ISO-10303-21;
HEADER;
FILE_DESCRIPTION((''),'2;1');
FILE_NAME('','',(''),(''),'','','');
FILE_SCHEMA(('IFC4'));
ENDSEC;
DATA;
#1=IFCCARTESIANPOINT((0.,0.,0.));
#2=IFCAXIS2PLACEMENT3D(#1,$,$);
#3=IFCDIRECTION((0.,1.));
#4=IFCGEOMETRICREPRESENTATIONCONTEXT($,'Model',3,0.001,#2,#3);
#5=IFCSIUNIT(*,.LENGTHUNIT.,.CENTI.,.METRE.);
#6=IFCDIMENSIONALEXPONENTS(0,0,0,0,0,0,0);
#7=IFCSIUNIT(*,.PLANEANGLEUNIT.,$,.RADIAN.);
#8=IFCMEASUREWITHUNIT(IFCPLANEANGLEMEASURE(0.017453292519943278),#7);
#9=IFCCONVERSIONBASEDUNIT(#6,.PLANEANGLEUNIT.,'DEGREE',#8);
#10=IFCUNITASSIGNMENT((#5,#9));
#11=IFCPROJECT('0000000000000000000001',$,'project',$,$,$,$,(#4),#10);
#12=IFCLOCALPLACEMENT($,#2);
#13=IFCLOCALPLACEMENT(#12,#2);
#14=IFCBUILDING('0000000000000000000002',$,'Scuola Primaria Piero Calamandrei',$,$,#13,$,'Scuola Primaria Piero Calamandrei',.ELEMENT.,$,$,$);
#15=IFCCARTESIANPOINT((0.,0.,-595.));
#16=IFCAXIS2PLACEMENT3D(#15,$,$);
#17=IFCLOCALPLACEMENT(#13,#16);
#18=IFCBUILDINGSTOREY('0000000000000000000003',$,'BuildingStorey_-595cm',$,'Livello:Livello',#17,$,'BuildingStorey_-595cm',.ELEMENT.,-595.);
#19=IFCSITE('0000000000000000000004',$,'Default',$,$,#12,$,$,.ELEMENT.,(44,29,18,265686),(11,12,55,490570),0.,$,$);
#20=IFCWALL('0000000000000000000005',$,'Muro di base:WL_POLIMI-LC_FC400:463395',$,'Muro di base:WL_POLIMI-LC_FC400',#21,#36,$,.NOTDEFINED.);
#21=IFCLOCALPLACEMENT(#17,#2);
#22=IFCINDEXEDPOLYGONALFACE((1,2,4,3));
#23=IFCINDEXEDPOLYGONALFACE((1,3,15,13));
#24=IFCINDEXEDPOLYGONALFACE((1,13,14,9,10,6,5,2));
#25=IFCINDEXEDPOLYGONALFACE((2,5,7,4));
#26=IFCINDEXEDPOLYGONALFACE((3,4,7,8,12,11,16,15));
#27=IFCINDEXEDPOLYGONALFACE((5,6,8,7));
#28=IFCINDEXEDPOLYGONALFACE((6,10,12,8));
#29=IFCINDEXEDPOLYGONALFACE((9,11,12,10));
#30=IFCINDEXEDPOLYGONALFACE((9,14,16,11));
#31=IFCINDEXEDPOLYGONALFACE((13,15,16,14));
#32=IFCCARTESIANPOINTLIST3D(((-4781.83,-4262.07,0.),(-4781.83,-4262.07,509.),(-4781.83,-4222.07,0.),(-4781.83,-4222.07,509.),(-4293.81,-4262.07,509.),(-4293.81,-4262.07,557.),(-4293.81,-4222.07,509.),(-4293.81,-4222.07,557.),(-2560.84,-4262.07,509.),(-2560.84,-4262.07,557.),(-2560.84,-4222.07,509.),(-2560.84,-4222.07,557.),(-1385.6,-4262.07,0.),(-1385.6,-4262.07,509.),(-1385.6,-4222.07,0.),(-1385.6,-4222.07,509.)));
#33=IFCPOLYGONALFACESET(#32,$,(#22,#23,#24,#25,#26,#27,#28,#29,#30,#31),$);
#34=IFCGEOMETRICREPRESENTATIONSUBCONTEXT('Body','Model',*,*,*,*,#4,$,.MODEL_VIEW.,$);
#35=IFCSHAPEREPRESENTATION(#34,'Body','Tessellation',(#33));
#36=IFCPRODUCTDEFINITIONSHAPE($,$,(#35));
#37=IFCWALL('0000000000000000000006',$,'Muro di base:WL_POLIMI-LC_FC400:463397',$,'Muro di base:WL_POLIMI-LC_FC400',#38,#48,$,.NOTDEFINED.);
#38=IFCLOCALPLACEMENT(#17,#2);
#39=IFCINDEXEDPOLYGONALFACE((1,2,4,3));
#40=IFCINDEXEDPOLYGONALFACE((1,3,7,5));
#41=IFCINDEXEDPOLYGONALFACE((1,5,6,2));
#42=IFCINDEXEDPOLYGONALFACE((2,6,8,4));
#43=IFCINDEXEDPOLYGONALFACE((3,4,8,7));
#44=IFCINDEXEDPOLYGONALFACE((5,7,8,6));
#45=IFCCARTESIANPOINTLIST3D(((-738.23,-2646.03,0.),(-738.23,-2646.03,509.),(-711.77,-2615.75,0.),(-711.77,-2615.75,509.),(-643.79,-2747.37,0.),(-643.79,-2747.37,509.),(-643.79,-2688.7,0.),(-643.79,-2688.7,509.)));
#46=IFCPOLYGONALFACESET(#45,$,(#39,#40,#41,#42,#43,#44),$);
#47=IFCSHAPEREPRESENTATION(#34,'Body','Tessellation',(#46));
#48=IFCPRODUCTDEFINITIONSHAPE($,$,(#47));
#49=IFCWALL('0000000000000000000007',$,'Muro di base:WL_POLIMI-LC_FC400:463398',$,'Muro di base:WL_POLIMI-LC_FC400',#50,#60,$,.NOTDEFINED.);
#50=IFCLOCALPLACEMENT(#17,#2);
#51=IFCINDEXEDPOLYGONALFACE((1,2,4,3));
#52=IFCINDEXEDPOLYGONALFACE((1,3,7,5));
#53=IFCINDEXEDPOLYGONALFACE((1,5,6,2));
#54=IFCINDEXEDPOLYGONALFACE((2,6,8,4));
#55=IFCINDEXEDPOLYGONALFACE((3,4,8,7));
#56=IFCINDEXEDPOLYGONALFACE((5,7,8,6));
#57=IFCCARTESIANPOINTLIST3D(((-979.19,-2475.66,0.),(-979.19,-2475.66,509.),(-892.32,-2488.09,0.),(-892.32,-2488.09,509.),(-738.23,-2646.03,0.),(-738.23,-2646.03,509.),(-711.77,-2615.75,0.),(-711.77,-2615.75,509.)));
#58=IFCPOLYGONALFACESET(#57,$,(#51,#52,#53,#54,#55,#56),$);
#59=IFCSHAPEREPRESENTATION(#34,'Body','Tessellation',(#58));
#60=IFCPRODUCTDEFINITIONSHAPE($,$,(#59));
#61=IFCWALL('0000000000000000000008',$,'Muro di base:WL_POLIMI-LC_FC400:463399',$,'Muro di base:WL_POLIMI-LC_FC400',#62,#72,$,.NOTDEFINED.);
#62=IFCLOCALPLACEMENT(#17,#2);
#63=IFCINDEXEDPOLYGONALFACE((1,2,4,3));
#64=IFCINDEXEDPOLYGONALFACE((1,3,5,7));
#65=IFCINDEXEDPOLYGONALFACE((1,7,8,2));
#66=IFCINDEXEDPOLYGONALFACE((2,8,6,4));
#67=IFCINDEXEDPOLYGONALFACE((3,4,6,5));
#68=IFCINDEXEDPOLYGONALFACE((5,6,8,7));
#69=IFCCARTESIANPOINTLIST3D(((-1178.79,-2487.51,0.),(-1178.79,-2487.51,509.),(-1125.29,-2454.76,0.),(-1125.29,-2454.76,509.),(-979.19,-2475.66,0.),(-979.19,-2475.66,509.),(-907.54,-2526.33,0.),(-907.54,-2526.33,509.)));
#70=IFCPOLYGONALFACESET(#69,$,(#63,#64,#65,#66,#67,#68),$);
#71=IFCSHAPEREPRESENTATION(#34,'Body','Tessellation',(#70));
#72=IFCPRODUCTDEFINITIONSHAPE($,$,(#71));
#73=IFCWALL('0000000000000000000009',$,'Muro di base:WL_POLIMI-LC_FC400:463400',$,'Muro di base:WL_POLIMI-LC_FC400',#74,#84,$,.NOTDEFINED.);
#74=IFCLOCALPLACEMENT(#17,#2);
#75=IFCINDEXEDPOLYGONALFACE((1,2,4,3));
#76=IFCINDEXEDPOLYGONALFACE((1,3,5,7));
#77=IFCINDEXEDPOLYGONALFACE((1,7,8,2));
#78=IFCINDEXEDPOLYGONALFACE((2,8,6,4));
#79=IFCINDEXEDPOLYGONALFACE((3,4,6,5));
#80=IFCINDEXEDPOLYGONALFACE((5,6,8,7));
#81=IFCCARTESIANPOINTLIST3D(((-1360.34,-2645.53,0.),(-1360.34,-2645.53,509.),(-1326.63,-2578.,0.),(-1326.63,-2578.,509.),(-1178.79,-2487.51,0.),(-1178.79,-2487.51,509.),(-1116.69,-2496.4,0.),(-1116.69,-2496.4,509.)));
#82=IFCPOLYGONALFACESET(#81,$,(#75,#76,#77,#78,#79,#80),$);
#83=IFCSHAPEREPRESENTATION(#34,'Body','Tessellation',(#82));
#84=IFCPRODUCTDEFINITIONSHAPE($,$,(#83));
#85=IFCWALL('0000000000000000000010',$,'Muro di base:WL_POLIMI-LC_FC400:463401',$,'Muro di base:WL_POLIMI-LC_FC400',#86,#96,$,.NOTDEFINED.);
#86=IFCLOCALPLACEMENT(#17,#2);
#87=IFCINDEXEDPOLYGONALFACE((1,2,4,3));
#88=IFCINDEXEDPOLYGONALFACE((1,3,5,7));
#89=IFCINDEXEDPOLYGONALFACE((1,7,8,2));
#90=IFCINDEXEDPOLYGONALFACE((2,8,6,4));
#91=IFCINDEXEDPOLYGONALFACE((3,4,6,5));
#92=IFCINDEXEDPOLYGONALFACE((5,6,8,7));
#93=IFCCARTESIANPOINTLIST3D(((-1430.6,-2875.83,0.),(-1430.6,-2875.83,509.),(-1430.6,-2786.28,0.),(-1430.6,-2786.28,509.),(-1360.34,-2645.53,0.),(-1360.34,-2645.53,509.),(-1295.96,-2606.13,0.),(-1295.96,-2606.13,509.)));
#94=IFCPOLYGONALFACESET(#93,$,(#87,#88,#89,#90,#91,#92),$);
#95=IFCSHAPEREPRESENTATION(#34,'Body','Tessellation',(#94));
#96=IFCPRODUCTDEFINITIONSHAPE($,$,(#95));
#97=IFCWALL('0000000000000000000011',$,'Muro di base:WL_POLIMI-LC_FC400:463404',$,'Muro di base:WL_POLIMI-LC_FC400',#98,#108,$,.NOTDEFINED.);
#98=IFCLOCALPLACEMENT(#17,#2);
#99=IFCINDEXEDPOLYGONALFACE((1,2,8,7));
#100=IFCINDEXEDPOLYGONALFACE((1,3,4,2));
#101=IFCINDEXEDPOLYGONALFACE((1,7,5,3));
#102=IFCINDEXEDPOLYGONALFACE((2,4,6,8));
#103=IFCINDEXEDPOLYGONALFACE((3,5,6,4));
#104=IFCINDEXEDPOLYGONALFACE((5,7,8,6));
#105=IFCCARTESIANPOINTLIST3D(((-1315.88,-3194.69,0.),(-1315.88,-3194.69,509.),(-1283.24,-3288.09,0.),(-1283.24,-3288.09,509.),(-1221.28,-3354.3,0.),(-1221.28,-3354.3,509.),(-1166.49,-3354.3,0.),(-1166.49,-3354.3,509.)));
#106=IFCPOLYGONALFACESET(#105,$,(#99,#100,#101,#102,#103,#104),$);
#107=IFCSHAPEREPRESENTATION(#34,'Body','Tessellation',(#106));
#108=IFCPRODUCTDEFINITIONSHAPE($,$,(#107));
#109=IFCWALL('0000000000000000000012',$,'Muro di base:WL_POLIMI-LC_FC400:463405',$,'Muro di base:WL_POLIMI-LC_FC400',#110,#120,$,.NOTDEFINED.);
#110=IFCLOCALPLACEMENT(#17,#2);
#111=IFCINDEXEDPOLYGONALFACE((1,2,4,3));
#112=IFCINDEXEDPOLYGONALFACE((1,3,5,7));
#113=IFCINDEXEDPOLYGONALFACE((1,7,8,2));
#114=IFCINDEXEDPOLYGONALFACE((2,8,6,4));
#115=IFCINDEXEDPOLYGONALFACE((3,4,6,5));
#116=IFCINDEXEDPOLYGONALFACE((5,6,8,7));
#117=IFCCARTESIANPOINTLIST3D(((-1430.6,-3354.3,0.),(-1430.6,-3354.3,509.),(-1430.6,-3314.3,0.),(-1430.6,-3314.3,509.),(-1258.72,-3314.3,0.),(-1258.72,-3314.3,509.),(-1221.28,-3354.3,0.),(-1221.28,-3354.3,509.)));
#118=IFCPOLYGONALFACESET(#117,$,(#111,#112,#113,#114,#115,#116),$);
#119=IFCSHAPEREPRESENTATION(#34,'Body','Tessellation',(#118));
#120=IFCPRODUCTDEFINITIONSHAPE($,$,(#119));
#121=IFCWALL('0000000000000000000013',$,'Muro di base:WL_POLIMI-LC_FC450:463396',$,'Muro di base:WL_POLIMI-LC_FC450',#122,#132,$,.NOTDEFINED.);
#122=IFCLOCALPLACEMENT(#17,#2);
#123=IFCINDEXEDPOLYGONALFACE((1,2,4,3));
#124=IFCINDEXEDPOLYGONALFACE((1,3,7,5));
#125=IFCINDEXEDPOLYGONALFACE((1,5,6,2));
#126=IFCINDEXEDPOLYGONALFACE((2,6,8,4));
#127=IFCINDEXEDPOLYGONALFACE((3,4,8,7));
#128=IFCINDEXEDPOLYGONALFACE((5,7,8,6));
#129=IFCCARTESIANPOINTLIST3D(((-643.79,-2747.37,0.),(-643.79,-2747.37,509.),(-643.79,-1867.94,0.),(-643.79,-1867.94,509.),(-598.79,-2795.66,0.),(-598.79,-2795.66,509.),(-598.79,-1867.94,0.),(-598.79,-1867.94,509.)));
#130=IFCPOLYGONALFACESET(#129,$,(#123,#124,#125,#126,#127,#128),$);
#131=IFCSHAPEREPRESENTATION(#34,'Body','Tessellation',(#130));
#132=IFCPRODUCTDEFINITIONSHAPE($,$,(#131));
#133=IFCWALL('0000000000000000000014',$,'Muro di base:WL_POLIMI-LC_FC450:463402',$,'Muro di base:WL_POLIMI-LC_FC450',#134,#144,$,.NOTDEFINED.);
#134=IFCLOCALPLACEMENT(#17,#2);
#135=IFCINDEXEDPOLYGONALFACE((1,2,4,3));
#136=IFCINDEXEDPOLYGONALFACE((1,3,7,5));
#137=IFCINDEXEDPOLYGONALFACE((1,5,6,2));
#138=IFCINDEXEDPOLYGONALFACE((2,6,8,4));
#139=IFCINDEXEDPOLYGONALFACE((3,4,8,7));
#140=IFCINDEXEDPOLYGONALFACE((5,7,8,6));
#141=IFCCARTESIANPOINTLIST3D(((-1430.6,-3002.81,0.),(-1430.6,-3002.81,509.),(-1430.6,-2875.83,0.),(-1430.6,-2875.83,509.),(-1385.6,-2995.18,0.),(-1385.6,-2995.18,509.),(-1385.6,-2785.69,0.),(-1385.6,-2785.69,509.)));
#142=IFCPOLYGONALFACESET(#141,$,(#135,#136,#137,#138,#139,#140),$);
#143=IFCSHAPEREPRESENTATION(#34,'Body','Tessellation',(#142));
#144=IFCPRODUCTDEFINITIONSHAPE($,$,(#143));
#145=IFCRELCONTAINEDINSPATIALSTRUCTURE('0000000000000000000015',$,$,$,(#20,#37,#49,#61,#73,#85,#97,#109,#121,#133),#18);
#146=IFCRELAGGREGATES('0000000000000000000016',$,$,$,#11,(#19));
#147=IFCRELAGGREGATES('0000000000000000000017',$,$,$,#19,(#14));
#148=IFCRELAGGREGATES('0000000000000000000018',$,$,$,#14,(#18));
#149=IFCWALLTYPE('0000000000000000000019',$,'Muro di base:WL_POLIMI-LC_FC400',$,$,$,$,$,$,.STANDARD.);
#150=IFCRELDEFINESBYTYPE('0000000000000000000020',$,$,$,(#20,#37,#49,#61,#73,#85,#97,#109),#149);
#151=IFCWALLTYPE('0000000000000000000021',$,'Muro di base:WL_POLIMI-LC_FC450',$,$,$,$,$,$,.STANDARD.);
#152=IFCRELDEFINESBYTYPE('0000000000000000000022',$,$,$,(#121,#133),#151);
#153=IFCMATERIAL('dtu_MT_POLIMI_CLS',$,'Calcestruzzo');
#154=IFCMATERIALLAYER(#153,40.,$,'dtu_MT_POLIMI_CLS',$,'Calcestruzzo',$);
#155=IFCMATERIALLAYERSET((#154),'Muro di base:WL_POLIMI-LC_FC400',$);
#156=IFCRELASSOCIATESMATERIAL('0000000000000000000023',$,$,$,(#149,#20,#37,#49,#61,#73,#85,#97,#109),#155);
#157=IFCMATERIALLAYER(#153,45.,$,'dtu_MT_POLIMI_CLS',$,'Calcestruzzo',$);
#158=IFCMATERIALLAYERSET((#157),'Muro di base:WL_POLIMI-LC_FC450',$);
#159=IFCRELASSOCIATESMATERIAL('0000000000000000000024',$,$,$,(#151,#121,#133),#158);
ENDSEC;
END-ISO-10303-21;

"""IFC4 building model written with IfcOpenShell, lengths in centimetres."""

from ifc_helpers import new_model, entity, si_unit, converted_unit, direction, frame, frame_2d, origin, place, context, subcontext, project, spatial, polyline, rectangle, outline, extrude, clip, bounded_halfspace, material, layer, layer_set, layer_usage, type_object, element, save


model = new_model("IFC4")

# Units and contexts
model_context = context("Model", 3, precision=0.001, world=origin(), true_north=direction((0.0, 1.0)))
body_context = subcontext(model_context, "Body", "Model", "MODEL_VIEW")
ifc_project = project(units=[si_unit("LENGTHUNIT", "METRE", prefix="CENTI"), converted_unit("PLANEANGLEUNIT", "DEGREE", entity("IfcPlaneAngleMeasure", 0.017453292519943278), si_unit("PLANEANGLEUNIT", "RADIAN"), dimensions=[0, 0, 0, 0, 0, 0, 0])], contexts=[model_context])

# Site, building, storey
site_placement = place(None, origin())
site = spatial("IfcSite", under=ifc_project, at=site_placement, Name="Default", CompositionType="ELEMENT", RefLatitude=(44, 29, 18, 265686), RefLongitude=(11, 12, 55, 490570), RefElevation=0.0)
building_placement = place(site_placement, origin())
building = spatial("IfcBuilding", under=site, at=building_placement, Name="Scuola Primaria Piero Calamandrei", LongName="Scuola Primaria Piero Calamandrei", CompositionType="ELEMENT")
storey_placement = place(building_placement, frame((0.0, 0.0, -595.0)))
storey = spatial("IfcBuildingStorey", under=building, at=storey_placement, Name="BuildingStorey_-595cm", ObjectType="Livello:Livello", LongName="BuildingStorey_-595cm", CompositionType="ELEMENT", Elevation=-595.0)

# Walls
ifc_material_1 = material(Name="dtu_MT_POLIMI_CLS", Category="Calcestruzzo")
ifc_layer_1 = layer(ifc_material_1, 40.0, Name="dtu_MT_POLIMI_CLS", Category="Calcestruzzo")
ifc_layer_set_1 = layer_set([ifc_layer_1], Name="Muro di base:WL_POLIMI-LC_FC400")
ifc_layer_usage_1 = layer_usage(ifc_layer_set_1, "AXIS2", "NEGATIVE", 20.0)
wall_type_1 = type_object("IfcWallType", Name="Muro di base:WL_POLIMI-LC_FC400", PredefinedType="STANDARD", material=ifc_layer_set_1)
wall_1_placement = place(storey_placement, frame((-1385.6, -4242.07, 0.0), z_axis=(0.0, 0.0, 1.0), x_axis=(-1.0, 0.0, 0.0)))
element("IfcWall", 1, at=wall_1_placement, inside=storey, type_object=wall_type_1, material=ifc_layer_usage_1, Name="Muro di base:WL_POLIMI-LC_FC400:463395", ObjectType="Muro di base:WL_POLIMI-LC_FC400", PredefinedType="NOTDEFINED", context=body_context, shape_type="Clipping", body=[
    clip(clip(clip(extrude(rectangle(XDim=3396.23, YDim=40.0, at=frame_2d((1698.11, 0.0), x_axis=(-1.0, 0.0))), origin(), (0.0, 0.0, 1.0), 557.0), bounded_halfspace(frame((1175.23, -20.0, 557.0), z_axis=(0.0, 0.0, -1.0), x_axis=(-1.0, 0.0, 0.0)), True, frame((1175.23, -20.0, 557.0)), polyline([(0.0, 0.0), (1732.97, 0.0), (1732.97, 40.0), (0.0, 40.0), (0.0, 0.0)]))), bounded_halfspace(frame((0.0, -20.0, 509.0), z_axis=(0.0, 0.0, 1.0), x_axis=(-1.0, 0.0, 0.0)), False, frame((0.0, -20.0, 509.0)), polyline([(0.0, 0.0), (45.0, 0.0), (1175.23, 0.0), (1175.23, 40.0), (0.0, 40.0), (0.0, 0.0)]))), bounded_halfspace(frame((2908.21, -20.0, 509.0), z_axis=(0.0, 0.0, 1.0), x_axis=(-1.0, 0.0, 0.0)), False, frame((2908.21, -20.0, 509.0)), polyline([(0.0, 0.0), (473.52, 0.0), (488.02, 0.0), (488.02, 40.0), (0.0, 40.0), (0.0, 0.0)]))),
])
ifc_layer_usage_2 = layer_usage(ifc_layer_set_1, "AXIS2", "NEGATIVE", 20.0)
wall_2_placement = place(storey_placement, frame((-629.16, -2733.74, 0.0), z_axis=(0.0, 0.0, 1.0), x_axis=(-0.681735, 0.731599, 0.0)))
element("IfcWall", 2, at=wall_2_placement, inside=storey, type_object=wall_type_1, material=ifc_layer_usage_2, Name="Muro di base:WL_POLIMI-LC_FC400:463397", ObjectType="Muro di base:WL_POLIMI-LC_FC400", PredefinedType="NOTDEFINED", context=body_context, shape_type="Clipping", body=[
    clip(extrude(outline(polyline([(142.64, -20.0), (138.52, 20.0), (0.0, 20.0), (42.93, -20.0), (142.64, -20.0)])), origin(), (0.0, 0.0, 1.0), 509.0), bounded_halfspace(frame((42.93, -20.0, 509.0), z_axis=(0.0, 0.0, 1.0), x_axis=(-0.681735, -0.731599, 0.0)), False, frame((42.93, -20.0, 509.0)), polyline([(0.0, 0.0), (99.71, 0.0), (95.6, 40.0), (-42.93, 40.0), (0.0, 0.0)]))),
])
ifc_layer_usage_3 = layer_usage(ifc_layer_set_1, "AXIS2", "NEGATIVE", 20.0)
wall_3_placement = place(storey_placement, frame((-723.32, -2632.08, 0.0), z_axis=(0.0, 0.0, 1.0), x_axis=(-0.816533, 0.577299, 0.0)))
element("IfcWall", 3, at=wall_3_placement, inside=storey, type_object=wall_type_1, material=ifc_layer_usage_3, Name="Muro di base:WL_POLIMI-LC_FC400:463398", ObjectType="Muro di base:WL_POLIMI-LC_FC400", PredefinedType="NOTDEFINED", context=body_context, shape_type="Clipping", body=[
    clip(extrude(outline(polyline([(221.12, -20.0), (299.23, 20.0), (211.48, 20.0), (4.12, 20.0), (0.0, -20.0), (221.12, -20.0)])), origin(), (0.0, 0.0, 1.0), 509.0), bounded_halfspace(frame((0.0, -20.0, 509.0), z_axis=(0.0, 0.0, 1.0), x_axis=(-0.816533, -0.577299, 0.0)), False, frame((0.0, -20.0, 509.0)), polyline([(0.0, 0.0), (221.12, 0.0), (299.23, 40.0), (211.48, 40.0), (4.12, 40.0), (0.0, 0.0)]))),
])
ifc_layer_usage_4 = layer_usage(ifc_layer_set_1, "AXIS2", "NEGATIVE", 20.0)
wall_4_placement = place(storey_placement, frame((-904.71, -2506.53, 0.0), z_axis=(0.0, 0.0, 1.0), x_axis=(-0.989918, 0.141644, 0.0)))
element("IfcWall", 4, at=wall_4_placement, inside=storey, type_object=wall_type_1, material=ifc_layer_usage_4, Name="Muro di base:WL_POLIMI-LC_FC400:463399", ObjectType="Muro di base:WL_POLIMI-LC_FC400", PredefinedType="NOTDEFINED", context=body_context, shape_type="Clipping", body=[
    clip(extrude(outline(polyline([(225.69, -20.0), (274.02, 20.0), (211.28, 20.0), (0.0, 20.0), (78.11, -20.0), (225.69, -20.0)])), origin(), (0.0, 0.0, 1.0), 509.0), bounded_halfspace(frame((78.11, -20.0, 509.0), z_axis=(0.0, 0.0, 1.0), x_axis=(-0.989918, -0.141644, 0.0)), False, frame((78.11, -20.0, 509.0)), polyline([(0.0, 0.0), (147.58, 0.0), (195.91, 40.0), (133.18, 40.0), (-78.11, 40.0), (0.0, 0.0)]))),
])
ifc_layer_usage_5 = layer_usage(ifc_layer_set_1, "AXIS2", "NEGATIVE", 20.0)
wall_5_placement = place(storey_placement, frame((-1127.13, -2479.34, 0.0), z_axis=(0.0, 0.0, 1.0), x_axis=(-0.85291, -0.522058, 0.0)))
element("IfcWall", 5, at=wall_5_placement, inside=storey, type_object=wall_type_1, material=ifc_layer_usage_5, Name="Muro di base:WL_POLIMI-LC_FC400:463400", ObjectType="Muro di base:WL_POLIMI-LC_FC400", PredefinedType="NOTDEFINED", context=body_context, shape_type="Clipping", body=[
    clip(extrude(outline(polyline([(221.66, -20.0), (285.67, 20.0), (210.19, 20.0), (0.0, 20.0), (48.33, -20.0), (221.66, -20.0)])), origin(), (0.0, 0.0, 1.0), 509.0), bounded_halfspace(frame((48.33, -20.0, 509.0), z_axis=(0.0, 0.0, 1.0), x_axis=(-0.85291, 0.522058, 0.0)), False, frame((48.33, -20.0, 509.0)), polyline([(0.0, 0.0), (173.33, 0.0), (237.34, 40.0), (161.86, 40.0), (-48.33, 40.0), (0.0, 0.0)]))),
])
ifc_layer_usage_6 = layer_usage(ifc_layer_set_1, "AXIS2", "NEGATIVE", 20.0)
wall_6_placement = place(storey_placement, frame((-1313.86, -2597.2, 0.0), z_axis=(0.0, 0.0, 1.0), x_axis=(-0.446642, -0.894713, 0.0)))
element("IfcWall", 6, at=wall_6_placement, inside=storey, type_object=wall_type_1, material=ifc_layer_usage_6, Name="Muro di base:WL_POLIMI-LC_FC400:463401", ObjectType="Muro di base:WL_POLIMI-LC_FC400", PredefinedType="NOTDEFINED", context=body_context, shape_type="Clipping", body=[
    clip(extrude(outline(polyline([(221.31, -20.0), (301.44, 20.0), (200.69, 20.0), (0.0, 20.0), (64.01, -20.0), (221.31, -20.0)])), origin(), (0.0, 0.0, 1.0), 509.0), bounded_halfspace(frame((64.01, -20.0, 509.0), z_axis=(0.0, 0.0, 1.0), x_axis=(-0.446642, 0.894713, 0.0)), False, frame((64.01, -20.0, 509.0)), polyline([(0.0, 0.0), (157.3, 0.0), (237.43, 40.0), (136.68, 40.0), (-64.01, 40.0), (0.0, 0.0)]))),
])
ifc_layer_usage_7 = layer_usage(ifc_layer_set_1, "AXIS2", "NEGATIVE", 20.0)
wall_7_placement = place(storey_placement, frame((-1330.49, -3208.35, 0.0), z_axis=(0.0, 0.0, 1.0), x_axis=(0.683359, -0.730082, 0.0)))
element("IfcWall", 7, at=wall_7_placement, inside=storey, type_object=wall_type_1, material=ifc_layer_usage_7, Name="Muro di base:WL_POLIMI-LC_FC400:463404", ObjectType="Muro di base:WL_POLIMI-LC_FC400", PredefinedType="NOTDEFINED", context=body_context, shape_type="Clipping", body=[
    clip(extrude(outline(polyline([(181.18, -20.0), (218.62, 20.0), (0.0, 20.0), (90.5, -20.0), (126.39, -20.0), (181.18, -20.0)])), origin(), (0.0, 0.0, 1.0), 509.0), bounded_halfspace(frame((90.5, -20.0, 509.0), z_axis=(0.0, 0.0, 1.0), x_axis=(0.683359, 0.730082, 0.0)), False, frame((90.5, -20.0, 509.0)), polyline([(0.0, 0.0), (35.89, 0.0), (90.68, 0.0), (128.12, 40.0), (-90.5, 40.0), (0.0, 0.0)]))),
])
ifc_layer_usage_8 = layer_usage(ifc_layer_set_1, "AXIS2", "NEGATIVE", 20.0)
wall_8_placement = place(storey_placement, frame((-1221.28, -3334.3, 0.0), z_axis=(0.0, 0.0, 1.0), x_axis=(-1.0, 0.0, 0.0)))
element("IfcWall", 8, at=wall_8_placement, inside=storey, type_object=wall_type_1, material=ifc_layer_usage_8, Name="Muro di base:WL_POLIMI-LC_FC400:463405", ObjectType="Muro di base:WL_POLIMI-LC_FC400", PredefinedType="NOTDEFINED", context=body_context, shape_type="Clipping", body=[
    clip(extrude(outline(polyline([(209.32, -20.0), (209.32, 20.0), (164.32, 20.0), (0.0, 20.0), (37.44, -20.0), (209.32, -20.0)])), origin(), (0.0, 0.0, 1.0), 509.0), bounded_halfspace(frame((37.44, -20.0, 509.0), z_axis=(0.0, 0.0, 1.0), x_axis=(-1.0, 0.0, 0.0)), False, frame((37.44, -20.0, 509.0)), polyline([(0.0, 0.0), (171.88, 0.0), (171.88, 40.0), (126.88, 40.0), (-37.44, 40.0), (0.0, 0.0)]))),
])
ifc_layer_2 = layer(ifc_material_1, 45.0, Name="dtu_MT_POLIMI_CLS", Category="Calcestruzzo")
ifc_layer_set_2 = layer_set([ifc_layer_2], Name="Muro di base:WL_POLIMI-LC_FC450")
ifc_layer_usage_9 = layer_usage(ifc_layer_set_2, "AXIS2", "NEGATIVE", 22.5)
wall_type_2 = type_object("IfcWallType", Name="Muro di base:WL_POLIMI-LC_FC450", PredefinedType="STANDARD", material=ifc_layer_set_2)
wall_9_placement = place(storey_placement, frame((-621.29, -1867.94, 0.0), z_axis=(0.0, 0.0, 1.0), x_axis=(0.0, -1.0, 0.0)))
element("IfcWall", 9, at=wall_9_placement, inside=storey, type_object=wall_type_2, material=ifc_layer_usage_9, Name="Muro di base:WL_POLIMI-LC_FC450:463396", ObjectType="Muro di base:WL_POLIMI-LC_FC450", PredefinedType="NOTDEFINED", context=body_context, shape_type="Clipping", body=[
    clip(extrude(outline(polyline([(879.44, -22.5), (927.73, 22.5), (0.0, 22.5), (0.0, -22.5), (10.75, -22.5), (820.76, -22.5), (879.44, -22.5)])), origin(), (0.0, 0.0, 1.0), 509.0), bounded_halfspace(frame((0.0, -22.5, 509.0), z_axis=(0.0, 0.0, 1.0), x_axis=(0.0, 1.0, 0.0)), False, frame((0.0, -22.5, 509.0)), polyline([(0.0, 0.0), (10.75, 0.0), (820.76, 0.0), (879.44, 0.0), (927.73, 45.0), (0.0, 45.0), (0.0, 0.0)]))),
])
ifc_layer_usage_10 = layer_usage(ifc_layer_set_2, "AXIS2", "NEGATIVE", 22.5)
wall_10_placement = place(storey_placement, frame((-1408.1, -2785.69, 0.0), z_axis=(0.0, 0.0, 1.0), x_axis=(0.0, -1.0, 0.0)))
element("IfcWall", 10, at=wall_10_placement, inside=storey, type_object=wall_type_2, material=ifc_layer_usage_10, Name="Muro di base:WL_POLIMI-LC_FC450:463402", ObjectType="Muro di base:WL_POLIMI-LC_FC450", PredefinedType="NOTDEFINED", context=body_context, shape_type="Clipping", body=[
    clip(extrude(outline(polyline([(217.12, -22.5), (209.49, 22.5), (0.0, 22.5), (90.14, -22.5), (217.12, -22.5)])), origin(), (0.0, 0.0, 1.0), 509.0), bounded_halfspace(frame((90.14, -22.5, 509.0), z_axis=(0.0, 0.0, 1.0), x_axis=(0.0, 1.0, 0.0)), False, frame((90.14, -22.5, 509.0)), polyline([(0.0, 0.0), (126.98, 0.0), (119.34, 45.0), (-90.14, 45.0), (0.0, 0.0)]))),
])

save(model, "model.ifc")
